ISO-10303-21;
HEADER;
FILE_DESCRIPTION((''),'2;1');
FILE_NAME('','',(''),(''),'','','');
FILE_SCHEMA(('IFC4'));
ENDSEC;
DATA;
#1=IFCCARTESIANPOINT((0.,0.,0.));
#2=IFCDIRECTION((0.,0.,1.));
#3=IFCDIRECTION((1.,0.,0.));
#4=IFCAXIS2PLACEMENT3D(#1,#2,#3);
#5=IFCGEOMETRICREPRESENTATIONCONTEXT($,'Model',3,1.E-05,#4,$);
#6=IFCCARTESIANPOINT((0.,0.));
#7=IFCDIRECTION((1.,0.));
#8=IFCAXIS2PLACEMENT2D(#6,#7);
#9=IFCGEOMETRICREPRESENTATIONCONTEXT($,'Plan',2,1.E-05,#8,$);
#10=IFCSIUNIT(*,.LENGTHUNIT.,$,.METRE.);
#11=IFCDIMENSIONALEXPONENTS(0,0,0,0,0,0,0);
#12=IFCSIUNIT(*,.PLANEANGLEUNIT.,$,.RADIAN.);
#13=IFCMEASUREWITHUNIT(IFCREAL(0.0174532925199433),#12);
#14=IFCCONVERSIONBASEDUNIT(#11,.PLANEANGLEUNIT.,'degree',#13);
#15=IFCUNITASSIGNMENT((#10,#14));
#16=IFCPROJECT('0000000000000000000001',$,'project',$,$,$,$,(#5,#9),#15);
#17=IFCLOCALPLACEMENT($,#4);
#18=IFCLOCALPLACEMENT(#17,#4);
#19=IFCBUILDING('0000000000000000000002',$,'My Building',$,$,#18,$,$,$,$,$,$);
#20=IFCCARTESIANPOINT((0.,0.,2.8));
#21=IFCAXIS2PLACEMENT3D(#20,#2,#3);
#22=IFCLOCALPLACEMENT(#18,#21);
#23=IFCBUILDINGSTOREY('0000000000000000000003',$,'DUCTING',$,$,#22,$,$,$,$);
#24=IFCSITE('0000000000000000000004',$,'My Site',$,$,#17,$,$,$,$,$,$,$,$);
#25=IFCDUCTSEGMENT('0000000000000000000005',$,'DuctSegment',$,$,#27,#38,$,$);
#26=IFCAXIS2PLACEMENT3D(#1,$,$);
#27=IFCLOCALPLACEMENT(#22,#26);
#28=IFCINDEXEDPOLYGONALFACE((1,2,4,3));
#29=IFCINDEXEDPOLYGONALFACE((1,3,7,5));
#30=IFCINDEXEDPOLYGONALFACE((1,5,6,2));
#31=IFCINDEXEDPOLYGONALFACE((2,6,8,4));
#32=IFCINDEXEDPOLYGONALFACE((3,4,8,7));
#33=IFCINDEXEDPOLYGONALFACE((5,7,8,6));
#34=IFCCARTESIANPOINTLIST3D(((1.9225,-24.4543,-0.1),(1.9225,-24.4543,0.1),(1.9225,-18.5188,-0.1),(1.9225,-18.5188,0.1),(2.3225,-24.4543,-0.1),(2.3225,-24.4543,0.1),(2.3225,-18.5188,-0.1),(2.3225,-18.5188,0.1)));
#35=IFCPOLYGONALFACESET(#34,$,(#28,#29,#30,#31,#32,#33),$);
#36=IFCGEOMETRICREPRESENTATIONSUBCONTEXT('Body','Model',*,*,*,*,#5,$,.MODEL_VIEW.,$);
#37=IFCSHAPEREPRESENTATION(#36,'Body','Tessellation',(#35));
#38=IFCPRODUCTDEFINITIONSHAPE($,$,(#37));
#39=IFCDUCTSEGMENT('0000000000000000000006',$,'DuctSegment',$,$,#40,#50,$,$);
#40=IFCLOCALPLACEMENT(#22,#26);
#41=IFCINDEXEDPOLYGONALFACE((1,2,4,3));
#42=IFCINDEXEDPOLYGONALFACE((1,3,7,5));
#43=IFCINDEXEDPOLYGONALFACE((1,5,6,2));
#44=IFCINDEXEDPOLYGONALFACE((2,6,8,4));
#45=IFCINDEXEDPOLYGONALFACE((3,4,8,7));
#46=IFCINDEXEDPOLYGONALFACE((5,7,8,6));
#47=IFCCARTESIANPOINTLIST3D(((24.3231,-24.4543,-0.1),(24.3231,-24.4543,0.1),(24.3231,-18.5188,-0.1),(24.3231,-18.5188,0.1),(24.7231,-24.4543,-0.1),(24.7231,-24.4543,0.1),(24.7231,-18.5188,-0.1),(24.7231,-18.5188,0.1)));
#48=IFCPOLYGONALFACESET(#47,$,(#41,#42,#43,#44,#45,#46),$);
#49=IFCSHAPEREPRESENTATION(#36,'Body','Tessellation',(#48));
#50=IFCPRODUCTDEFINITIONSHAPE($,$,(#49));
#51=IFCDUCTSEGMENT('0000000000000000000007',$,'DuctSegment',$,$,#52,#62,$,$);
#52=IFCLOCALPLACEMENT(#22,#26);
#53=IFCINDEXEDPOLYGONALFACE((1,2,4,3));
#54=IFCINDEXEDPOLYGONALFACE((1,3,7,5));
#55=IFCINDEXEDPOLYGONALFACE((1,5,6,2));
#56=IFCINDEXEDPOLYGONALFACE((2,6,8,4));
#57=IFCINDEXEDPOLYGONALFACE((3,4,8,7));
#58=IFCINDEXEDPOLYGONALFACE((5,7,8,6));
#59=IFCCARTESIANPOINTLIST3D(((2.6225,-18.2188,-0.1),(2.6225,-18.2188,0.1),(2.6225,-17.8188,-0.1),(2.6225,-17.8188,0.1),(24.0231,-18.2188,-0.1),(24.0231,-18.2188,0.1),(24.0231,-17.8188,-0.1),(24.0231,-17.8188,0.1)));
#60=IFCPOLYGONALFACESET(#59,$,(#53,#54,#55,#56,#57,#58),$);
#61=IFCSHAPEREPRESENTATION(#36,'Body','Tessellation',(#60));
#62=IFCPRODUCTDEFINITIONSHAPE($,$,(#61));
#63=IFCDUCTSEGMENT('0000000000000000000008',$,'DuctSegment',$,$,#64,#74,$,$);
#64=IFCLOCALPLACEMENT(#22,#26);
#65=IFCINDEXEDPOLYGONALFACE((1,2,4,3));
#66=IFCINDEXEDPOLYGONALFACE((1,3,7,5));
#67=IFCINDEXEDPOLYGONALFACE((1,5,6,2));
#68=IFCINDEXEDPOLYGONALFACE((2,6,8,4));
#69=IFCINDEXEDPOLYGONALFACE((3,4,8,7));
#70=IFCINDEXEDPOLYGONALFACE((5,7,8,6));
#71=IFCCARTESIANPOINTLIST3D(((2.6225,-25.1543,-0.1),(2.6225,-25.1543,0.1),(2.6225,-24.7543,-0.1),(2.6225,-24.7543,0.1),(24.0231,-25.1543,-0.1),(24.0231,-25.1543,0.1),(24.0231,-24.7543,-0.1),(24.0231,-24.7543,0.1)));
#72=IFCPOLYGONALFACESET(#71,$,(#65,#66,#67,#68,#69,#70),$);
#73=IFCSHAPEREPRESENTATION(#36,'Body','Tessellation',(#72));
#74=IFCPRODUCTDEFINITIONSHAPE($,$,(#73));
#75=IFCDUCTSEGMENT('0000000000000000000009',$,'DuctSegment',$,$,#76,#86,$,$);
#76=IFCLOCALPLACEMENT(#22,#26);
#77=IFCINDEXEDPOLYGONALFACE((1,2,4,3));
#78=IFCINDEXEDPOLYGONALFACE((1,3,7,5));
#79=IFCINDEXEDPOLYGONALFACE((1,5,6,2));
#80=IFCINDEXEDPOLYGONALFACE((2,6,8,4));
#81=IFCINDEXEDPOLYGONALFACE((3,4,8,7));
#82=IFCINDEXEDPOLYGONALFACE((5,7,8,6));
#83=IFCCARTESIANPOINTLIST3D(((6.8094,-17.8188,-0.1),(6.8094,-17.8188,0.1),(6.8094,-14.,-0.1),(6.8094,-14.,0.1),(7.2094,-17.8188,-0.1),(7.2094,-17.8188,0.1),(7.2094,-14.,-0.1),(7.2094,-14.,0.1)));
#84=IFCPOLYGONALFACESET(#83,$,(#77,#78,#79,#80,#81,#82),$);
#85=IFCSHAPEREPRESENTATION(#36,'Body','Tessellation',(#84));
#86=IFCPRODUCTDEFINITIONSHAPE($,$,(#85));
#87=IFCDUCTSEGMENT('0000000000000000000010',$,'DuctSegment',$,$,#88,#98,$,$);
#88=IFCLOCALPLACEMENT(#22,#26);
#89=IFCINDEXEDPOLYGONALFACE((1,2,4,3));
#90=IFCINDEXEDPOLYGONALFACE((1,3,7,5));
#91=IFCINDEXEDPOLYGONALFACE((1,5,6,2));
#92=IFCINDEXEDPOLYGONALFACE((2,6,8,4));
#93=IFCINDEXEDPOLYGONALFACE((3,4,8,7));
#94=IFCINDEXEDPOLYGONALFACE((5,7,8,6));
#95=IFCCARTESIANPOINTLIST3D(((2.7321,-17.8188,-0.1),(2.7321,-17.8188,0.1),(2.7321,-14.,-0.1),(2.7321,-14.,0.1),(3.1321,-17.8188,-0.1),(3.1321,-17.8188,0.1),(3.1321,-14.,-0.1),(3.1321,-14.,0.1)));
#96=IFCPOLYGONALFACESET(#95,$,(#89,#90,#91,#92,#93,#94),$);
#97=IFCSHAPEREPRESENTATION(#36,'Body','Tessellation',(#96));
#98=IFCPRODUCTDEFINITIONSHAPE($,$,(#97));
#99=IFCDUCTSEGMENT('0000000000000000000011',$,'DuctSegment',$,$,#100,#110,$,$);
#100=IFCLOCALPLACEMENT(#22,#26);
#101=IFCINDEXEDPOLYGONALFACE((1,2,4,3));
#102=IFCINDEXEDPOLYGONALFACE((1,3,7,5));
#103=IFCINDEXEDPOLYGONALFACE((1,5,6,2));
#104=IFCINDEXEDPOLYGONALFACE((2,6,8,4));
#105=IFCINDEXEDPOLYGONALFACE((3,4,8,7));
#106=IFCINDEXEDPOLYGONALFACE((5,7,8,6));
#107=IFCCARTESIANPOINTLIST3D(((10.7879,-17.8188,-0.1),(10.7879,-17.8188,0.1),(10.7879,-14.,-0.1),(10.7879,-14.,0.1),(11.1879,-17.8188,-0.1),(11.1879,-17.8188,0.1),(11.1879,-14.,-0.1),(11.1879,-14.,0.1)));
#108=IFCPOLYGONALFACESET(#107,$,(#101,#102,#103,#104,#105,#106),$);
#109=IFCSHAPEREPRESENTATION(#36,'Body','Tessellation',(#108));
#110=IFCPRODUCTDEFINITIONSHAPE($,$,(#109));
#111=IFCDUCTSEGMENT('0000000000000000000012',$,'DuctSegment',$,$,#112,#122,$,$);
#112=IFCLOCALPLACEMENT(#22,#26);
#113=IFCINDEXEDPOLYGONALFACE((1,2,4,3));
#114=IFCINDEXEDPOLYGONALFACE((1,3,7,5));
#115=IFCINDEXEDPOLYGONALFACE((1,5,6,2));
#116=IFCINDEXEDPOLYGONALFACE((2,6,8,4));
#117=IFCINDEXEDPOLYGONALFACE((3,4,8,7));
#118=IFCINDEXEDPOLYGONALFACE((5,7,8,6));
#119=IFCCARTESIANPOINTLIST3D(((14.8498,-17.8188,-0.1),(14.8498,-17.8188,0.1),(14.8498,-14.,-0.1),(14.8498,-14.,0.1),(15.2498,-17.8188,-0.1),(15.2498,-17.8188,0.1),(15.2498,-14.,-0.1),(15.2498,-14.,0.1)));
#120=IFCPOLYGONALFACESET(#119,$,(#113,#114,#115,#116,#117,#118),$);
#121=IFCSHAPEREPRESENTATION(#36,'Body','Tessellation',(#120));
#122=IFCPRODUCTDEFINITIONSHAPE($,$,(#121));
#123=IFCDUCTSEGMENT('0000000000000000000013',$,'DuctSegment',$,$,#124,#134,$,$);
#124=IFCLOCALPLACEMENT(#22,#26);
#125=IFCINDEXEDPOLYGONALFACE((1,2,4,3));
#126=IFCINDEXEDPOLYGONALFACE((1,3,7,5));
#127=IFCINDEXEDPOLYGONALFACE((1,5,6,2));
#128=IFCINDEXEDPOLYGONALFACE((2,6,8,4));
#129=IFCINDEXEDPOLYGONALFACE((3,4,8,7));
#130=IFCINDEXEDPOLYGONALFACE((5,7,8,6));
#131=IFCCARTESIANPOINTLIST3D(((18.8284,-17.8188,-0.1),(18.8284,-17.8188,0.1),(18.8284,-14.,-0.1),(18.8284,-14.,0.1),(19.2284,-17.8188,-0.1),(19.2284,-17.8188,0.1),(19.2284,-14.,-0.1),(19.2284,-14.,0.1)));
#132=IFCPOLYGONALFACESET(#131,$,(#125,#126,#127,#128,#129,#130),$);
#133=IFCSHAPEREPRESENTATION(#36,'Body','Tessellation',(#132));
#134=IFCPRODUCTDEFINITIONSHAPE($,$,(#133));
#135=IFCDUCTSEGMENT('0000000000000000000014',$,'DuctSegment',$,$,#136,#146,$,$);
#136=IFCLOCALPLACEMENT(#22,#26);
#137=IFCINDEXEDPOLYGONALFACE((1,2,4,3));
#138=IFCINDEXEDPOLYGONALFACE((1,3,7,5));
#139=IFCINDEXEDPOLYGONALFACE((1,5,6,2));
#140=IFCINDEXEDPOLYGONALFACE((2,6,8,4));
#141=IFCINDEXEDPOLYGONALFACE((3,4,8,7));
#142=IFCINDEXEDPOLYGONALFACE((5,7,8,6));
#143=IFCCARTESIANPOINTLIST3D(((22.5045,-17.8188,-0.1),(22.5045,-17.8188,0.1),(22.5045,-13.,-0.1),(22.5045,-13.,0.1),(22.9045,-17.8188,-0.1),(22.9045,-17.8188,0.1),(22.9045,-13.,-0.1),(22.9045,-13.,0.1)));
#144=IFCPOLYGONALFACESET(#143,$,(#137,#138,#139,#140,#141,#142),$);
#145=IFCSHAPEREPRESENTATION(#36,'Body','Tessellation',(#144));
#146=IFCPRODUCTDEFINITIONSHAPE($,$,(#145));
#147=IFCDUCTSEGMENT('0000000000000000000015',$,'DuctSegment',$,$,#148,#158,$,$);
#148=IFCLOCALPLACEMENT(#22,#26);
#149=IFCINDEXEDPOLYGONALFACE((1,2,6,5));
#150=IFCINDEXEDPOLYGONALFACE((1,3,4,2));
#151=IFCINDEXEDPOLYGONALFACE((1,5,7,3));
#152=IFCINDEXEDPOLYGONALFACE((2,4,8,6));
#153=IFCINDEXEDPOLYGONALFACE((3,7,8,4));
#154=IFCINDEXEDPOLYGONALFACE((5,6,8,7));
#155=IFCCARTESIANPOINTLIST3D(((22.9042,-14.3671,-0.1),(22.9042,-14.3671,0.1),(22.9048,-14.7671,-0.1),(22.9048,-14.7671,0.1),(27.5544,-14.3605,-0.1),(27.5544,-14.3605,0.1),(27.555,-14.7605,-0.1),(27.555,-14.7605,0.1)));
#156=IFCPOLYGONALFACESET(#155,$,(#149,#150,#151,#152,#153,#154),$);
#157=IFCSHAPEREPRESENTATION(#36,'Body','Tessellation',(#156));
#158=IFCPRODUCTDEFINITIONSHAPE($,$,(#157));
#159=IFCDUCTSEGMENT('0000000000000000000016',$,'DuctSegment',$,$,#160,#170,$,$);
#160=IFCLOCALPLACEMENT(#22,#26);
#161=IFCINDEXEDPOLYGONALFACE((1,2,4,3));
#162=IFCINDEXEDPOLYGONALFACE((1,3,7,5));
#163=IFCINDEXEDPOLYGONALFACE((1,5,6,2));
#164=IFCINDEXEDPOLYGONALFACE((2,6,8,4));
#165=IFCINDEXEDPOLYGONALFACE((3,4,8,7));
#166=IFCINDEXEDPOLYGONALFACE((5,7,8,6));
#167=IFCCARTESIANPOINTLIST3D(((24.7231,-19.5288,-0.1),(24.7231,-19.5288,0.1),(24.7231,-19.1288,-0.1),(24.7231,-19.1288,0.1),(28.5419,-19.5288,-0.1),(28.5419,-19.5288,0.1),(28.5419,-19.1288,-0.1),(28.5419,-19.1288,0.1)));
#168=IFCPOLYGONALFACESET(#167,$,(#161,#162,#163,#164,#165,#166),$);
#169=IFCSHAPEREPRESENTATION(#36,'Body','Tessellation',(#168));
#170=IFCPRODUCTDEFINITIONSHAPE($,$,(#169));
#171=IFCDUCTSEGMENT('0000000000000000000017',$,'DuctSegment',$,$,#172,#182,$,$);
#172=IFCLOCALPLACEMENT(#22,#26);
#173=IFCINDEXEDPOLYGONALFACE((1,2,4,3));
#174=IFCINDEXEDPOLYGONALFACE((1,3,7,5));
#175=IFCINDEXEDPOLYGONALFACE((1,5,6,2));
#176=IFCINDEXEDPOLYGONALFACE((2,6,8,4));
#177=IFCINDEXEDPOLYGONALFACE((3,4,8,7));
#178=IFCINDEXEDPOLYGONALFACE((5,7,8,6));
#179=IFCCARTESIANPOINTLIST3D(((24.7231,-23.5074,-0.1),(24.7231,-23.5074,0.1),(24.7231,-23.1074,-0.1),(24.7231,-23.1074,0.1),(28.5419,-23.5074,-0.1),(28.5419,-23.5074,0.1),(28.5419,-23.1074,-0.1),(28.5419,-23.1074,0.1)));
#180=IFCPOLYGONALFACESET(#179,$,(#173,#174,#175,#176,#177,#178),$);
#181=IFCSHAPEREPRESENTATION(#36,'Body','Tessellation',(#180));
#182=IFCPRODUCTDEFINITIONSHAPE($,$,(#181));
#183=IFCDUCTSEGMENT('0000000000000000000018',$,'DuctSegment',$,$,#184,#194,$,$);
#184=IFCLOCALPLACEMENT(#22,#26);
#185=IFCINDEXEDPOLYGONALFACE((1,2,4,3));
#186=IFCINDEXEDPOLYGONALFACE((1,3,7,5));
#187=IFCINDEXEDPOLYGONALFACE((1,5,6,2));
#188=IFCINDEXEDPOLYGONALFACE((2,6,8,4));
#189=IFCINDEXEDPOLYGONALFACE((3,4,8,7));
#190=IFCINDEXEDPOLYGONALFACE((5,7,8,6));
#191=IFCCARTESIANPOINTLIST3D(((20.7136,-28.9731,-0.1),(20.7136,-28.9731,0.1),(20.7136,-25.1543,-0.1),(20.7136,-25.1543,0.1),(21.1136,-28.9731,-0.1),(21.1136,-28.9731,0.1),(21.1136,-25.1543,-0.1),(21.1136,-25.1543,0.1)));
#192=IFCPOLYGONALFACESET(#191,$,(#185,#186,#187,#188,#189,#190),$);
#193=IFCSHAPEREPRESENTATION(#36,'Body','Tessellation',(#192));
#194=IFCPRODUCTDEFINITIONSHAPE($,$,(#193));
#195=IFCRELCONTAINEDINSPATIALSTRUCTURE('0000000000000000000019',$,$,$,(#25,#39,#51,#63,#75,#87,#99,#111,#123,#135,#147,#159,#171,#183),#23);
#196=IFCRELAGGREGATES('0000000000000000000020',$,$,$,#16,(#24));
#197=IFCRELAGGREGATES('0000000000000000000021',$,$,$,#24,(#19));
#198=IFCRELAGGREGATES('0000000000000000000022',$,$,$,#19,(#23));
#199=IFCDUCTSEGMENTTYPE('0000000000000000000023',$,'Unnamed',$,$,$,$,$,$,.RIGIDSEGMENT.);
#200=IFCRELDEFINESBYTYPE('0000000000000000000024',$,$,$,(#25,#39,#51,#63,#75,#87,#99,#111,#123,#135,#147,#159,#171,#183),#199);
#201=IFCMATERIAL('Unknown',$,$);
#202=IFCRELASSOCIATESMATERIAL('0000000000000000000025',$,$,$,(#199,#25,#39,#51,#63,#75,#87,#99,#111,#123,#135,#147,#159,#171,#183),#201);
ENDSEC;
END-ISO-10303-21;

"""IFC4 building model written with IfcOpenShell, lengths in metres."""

from ifc_helpers import new_model, entity, si_unit, converted_unit, frame, origin_with_axes, origin_2d_with_axis, place, context, subcontext, project, spatial, rectangle, extrude, material, material_profile, profile_set, profile_usage, type_object, element, save


model = new_model("IFC4")

# Units and contexts
model_context = context("Model", 3, precision=1e-05, world=origin_with_axes())
plan_context = context("Plan", 2, precision=1e-05, world=origin_2d_with_axis())
body_context = subcontext(model_context, "Body", "Model", "MODEL_VIEW")
ifc_project = project(units=[si_unit("LENGTHUNIT", "METRE"), converted_unit("PLANEANGLEUNIT", "degree", entity("IfcReal", 0.0174532925199433), si_unit("PLANEANGLEUNIT", "RADIAN"), dimensions=[0, 0, 0, 0, 0, 0, 0])], contexts=[model_context, plan_context])

# Site, building, storey
site_placement = place(None, origin_with_axes())
site = spatial("IfcSite", under=ifc_project, at=site_placement, Name="My Site")
building_placement = place(site_placement, origin_with_axes())
building = spatial("IfcBuilding", under=site, at=building_placement, Name="My Building")
storey_placement = place(building_placement, frame((0.0, 0.0, 2.8), z_axis=(0.0, 0.0, 1.0), x_axis=(1.0, 0.0, 0.0)))
storey = spatial("IfcBuildingStorey", under=building, at=storey_placement, Name="DUCTING")

# Duct segments
ifc_material = material(Name="Unknown")
ifc_material_profile = material_profile(ifc_material, rectangle(XDim=0.4, YDim=0.2))
ifc_profile_set = profile_set([ifc_material_profile])
ifc_profile_usage_1 = profile_usage(ifc_profile_set, cardinal=5)
duct_segment_type = type_object("IfcDuctSegmentType", Name="Unnamed", PredefinedType="RIGIDSEGMENT", material=ifc_profile_set)
duct_segment_1_placement = place(storey_placement, frame((2.1225, -18.5188, 0.0), z_axis=(0.000006, -1.0, 0.0), x_axis=(1.0, 0.000006, 0.0)))
element("IfcDuctSegment", 1, at=duct_segment_1_placement, inside=storey, type_object=duct_segment_type, material=ifc_profile_usage_1, Name="DuctSegment", context=body_context, shape_type="SweptSolid", body=[
    extrude(rectangle(XDim=0.4, YDim=0.2), origin_with_axes(), (0.0, 0.0, 1.0), 5.9355),
])
ifc_profile_usage_2 = profile_usage(ifc_profile_set, cardinal=5)
duct_segment_2_placement = place(storey_placement, frame((24.5231, -18.5188, 0.0), z_axis=(0.000006, -1.0, 0.0), x_axis=(1.0, 0.000006, 0.0)))
element("IfcDuctSegment", 2, at=duct_segment_2_placement, inside=storey, type_object=duct_segment_type, material=ifc_profile_usage_2, Name="DuctSegment", context=body_context, shape_type="SweptSolid", body=[
    extrude(rectangle(XDim=0.4, YDim=0.2), origin_with_axes(), (0.0, 0.0, 1.0), 5.9355),
])
ifc_profile_usage_3 = profile_usage(ifc_profile_set, cardinal=5)
duct_segment_3_placement = place(storey_placement, frame((2.6225, -18.0188, 0.0), z_axis=(1.0, -0.000001, 0.0), x_axis=(0.000001, 1.0, 0.0)))
element("IfcDuctSegment", 3, at=duct_segment_3_placement, inside=storey, type_object=duct_segment_type, material=ifc_profile_usage_3, Name="DuctSegment", context=body_context, shape_type="SweptSolid", body=[
    extrude(rectangle(XDim=0.4, YDim=0.2), origin_with_axes(), (0.0, 0.0, 1.0), 21.4006),
])
ifc_profile_usage_4 = profile_usage(ifc_profile_set, cardinal=5)
duct_segment_4_placement = place(storey_placement, frame((2.6225, -24.9543, 0.0), z_axis=(1.0, -0.000001, 0.0), x_axis=(0.000001, 1.0, 0.0)))
element("IfcDuctSegment", 4, at=duct_segment_4_placement, inside=storey, type_object=duct_segment_type, material=ifc_profile_usage_4, Name="DuctSegment", context=body_context, shape_type="SweptSolid", body=[
    extrude(rectangle(XDim=0.4, YDim=0.2), origin_with_axes(), (0.0, 0.0, 1.0), 21.4006),
])
ifc_profile_usage_5 = profile_usage(ifc_profile_set, cardinal=5)
duct_segment_5_placement = place(storey_placement, frame((7.0094, -17.8188, 0.0), z_axis=(0.0, 1.0, 0.0), x_axis=(-1.0, 0.0, 0.0)))
element("IfcDuctSegment", 5, at=duct_segment_5_placement, inside=storey, type_object=duct_segment_type, material=ifc_profile_usage_5, Name="DuctSegment", context=body_context, shape_type="SweptSolid", body=[
    extrude(rectangle(XDim=0.4, YDim=0.2), origin_with_axes(), (0.0, 0.0, 1.0), 3.8188),
])
ifc_profile_usage_6 = profile_usage(ifc_profile_set, cardinal=5)
duct_segment_6_placement = place(storey_placement, frame((2.9321, -17.8188, 0.0), z_axis=(0.0, 1.0, 0.0), x_axis=(-1.0, 0.0, 0.0)))
element("IfcDuctSegment", 6, at=duct_segment_6_placement, inside=storey, type_object=duct_segment_type, material=ifc_profile_usage_6, Name="DuctSegment", context=body_context, shape_type="SweptSolid", body=[
    extrude(rectangle(XDim=0.4, YDim=0.2), origin_with_axes(), (0.0, 0.0, 1.0), 3.8188),
])
ifc_profile_usage_7 = profile_usage(ifc_profile_set, cardinal=5)
duct_segment_7_placement = place(storey_placement, frame((10.9879, -17.8188, 0.0), z_axis=(0.0, 1.0, 0.0), x_axis=(-1.0, 0.0, 0.0)))
element("IfcDuctSegment", 7, at=duct_segment_7_placement, inside=storey, type_object=duct_segment_type, material=ifc_profile_usage_7, Name="DuctSegment", context=body_context, shape_type="SweptSolid", body=[
    extrude(rectangle(XDim=0.4, YDim=0.2), origin_with_axes(), (0.0, 0.0, 1.0), 3.8188),
])
ifc_profile_usage_8 = profile_usage(ifc_profile_set, cardinal=5)
duct_segment_8_placement = place(storey_placement, frame((15.0498, -17.8188, 0.0), z_axis=(0.0, 1.0, 0.0), x_axis=(-1.0, 0.0, 0.0)))
element("IfcDuctSegment", 8, at=duct_segment_8_placement, inside=storey, type_object=duct_segment_type, material=ifc_profile_usage_8, Name="DuctSegment", context=body_context, shape_type="SweptSolid", body=[
    extrude(rectangle(XDim=0.4, YDim=0.2), origin_with_axes(), (0.0, 0.0, 1.0), 3.8188),
])
ifc_profile_usage_9 = profile_usage(ifc_profile_set, cardinal=5)
duct_segment_9_placement = place(storey_placement, frame((19.0284, -17.8188, 0.0), z_axis=(0.0, 1.0, 0.0), x_axis=(-1.0, 0.0, 0.0)))
element("IfcDuctSegment", 9, at=duct_segment_9_placement, inside=storey, type_object=duct_segment_type, material=ifc_profile_usage_9, Name="DuctSegment", context=body_context, shape_type="SweptSolid", body=[
    extrude(rectangle(XDim=0.4, YDim=0.2), origin_with_axes(), (0.0, 0.0, 1.0), 3.8188),
])
ifc_profile_usage_10 = profile_usage(ifc_profile_set, cardinal=5)
duct_segment_10_placement = place(storey_placement, frame((22.7045, -17.8188, 0.0), z_axis=(0.0, 1.0, 0.0), x_axis=(-1.0, 0.0, 0.0)))
element("IfcDuctSegment", 10, at=duct_segment_10_placement, inside=storey, type_object=duct_segment_type, material=ifc_profile_usage_10, Name="DuctSegment", context=body_context, shape_type="SweptSolid", body=[
    extrude(rectangle(XDim=0.4, YDim=0.2), origin_with_axes(), (0.0, 0.0, 1.0), 4.8188),
])
ifc_profile_usage_11 = profile_usage(ifc_profile_set, cardinal=5)
duct_segment_11_placement = place(storey_placement, frame((22.9045, -14.5671, 0.0), z_axis=(0.999999, 0.001427, 0.0), x_axis=(-0.001427, 0.999999, 0.0)))
element("IfcDuctSegment", 11, at=duct_segment_11_placement, inside=storey, type_object=duct_segment_type, material=ifc_profile_usage_11, Name="DuctSegment", context=body_context, shape_type="SweptSolid", body=[
    extrude(rectangle(XDim=0.4, YDim=0.2), origin_with_axes(), (0.0, 0.0, 1.0), 4.6502),
])
ifc_profile_usage_12 = profile_usage(ifc_profile_set, cardinal=5)
duct_segment_12_placement = place(storey_placement, frame((24.7231, -19.3288, 0.0), z_axis=(1.0, 0.0, 0.0), x_axis=(0.0, 1.0, 0.0)))
element("IfcDuctSegment", 12, at=duct_segment_12_placement, inside=storey, type_object=duct_segment_type, material=ifc_profile_usage_12, Name="DuctSegment", context=body_context, shape_type="SweptSolid", body=[
    extrude(rectangle(XDim=0.4, YDim=0.2), origin_with_axes(), (0.0, 0.0, 1.0), 3.8188),
])
ifc_profile_usage_13 = profile_usage(ifc_profile_set, cardinal=5)
duct_segment_13_placement = place(storey_placement, frame((24.7231, -23.3074, 0.0), z_axis=(1.0, 0.0, 0.0), x_axis=(0.0, 1.0, 0.0)))
element("IfcDuctSegment", 13, at=duct_segment_13_placement, inside=storey, type_object=duct_segment_type, material=ifc_profile_usage_13, Name="DuctSegment", context=body_context, shape_type="SweptSolid", body=[
    extrude(rectangle(XDim=0.4, YDim=0.2), origin_with_axes(), (0.0, 0.0, 1.0), 3.8188),
])
ifc_profile_usage_14 = profile_usage(ifc_profile_set, cardinal=5)
duct_segment_14_placement = place(storey_placement, frame((20.9136, -25.1543, 0.0), z_axis=(0.0, -1.0, 0.0), x_axis=(1.0, 0.0, 0.0)))
element("IfcDuctSegment", 14, at=duct_segment_14_placement, inside=storey, type_object=duct_segment_type, material=ifc_profile_usage_14, Name="DuctSegment", context=body_context, shape_type="SweptSolid", body=[
    extrude(rectangle(XDim=0.4, YDim=0.2), origin_with_axes(), (0.0, 0.0, 1.0), 3.8188),
])

save(model, "model.ifc")
